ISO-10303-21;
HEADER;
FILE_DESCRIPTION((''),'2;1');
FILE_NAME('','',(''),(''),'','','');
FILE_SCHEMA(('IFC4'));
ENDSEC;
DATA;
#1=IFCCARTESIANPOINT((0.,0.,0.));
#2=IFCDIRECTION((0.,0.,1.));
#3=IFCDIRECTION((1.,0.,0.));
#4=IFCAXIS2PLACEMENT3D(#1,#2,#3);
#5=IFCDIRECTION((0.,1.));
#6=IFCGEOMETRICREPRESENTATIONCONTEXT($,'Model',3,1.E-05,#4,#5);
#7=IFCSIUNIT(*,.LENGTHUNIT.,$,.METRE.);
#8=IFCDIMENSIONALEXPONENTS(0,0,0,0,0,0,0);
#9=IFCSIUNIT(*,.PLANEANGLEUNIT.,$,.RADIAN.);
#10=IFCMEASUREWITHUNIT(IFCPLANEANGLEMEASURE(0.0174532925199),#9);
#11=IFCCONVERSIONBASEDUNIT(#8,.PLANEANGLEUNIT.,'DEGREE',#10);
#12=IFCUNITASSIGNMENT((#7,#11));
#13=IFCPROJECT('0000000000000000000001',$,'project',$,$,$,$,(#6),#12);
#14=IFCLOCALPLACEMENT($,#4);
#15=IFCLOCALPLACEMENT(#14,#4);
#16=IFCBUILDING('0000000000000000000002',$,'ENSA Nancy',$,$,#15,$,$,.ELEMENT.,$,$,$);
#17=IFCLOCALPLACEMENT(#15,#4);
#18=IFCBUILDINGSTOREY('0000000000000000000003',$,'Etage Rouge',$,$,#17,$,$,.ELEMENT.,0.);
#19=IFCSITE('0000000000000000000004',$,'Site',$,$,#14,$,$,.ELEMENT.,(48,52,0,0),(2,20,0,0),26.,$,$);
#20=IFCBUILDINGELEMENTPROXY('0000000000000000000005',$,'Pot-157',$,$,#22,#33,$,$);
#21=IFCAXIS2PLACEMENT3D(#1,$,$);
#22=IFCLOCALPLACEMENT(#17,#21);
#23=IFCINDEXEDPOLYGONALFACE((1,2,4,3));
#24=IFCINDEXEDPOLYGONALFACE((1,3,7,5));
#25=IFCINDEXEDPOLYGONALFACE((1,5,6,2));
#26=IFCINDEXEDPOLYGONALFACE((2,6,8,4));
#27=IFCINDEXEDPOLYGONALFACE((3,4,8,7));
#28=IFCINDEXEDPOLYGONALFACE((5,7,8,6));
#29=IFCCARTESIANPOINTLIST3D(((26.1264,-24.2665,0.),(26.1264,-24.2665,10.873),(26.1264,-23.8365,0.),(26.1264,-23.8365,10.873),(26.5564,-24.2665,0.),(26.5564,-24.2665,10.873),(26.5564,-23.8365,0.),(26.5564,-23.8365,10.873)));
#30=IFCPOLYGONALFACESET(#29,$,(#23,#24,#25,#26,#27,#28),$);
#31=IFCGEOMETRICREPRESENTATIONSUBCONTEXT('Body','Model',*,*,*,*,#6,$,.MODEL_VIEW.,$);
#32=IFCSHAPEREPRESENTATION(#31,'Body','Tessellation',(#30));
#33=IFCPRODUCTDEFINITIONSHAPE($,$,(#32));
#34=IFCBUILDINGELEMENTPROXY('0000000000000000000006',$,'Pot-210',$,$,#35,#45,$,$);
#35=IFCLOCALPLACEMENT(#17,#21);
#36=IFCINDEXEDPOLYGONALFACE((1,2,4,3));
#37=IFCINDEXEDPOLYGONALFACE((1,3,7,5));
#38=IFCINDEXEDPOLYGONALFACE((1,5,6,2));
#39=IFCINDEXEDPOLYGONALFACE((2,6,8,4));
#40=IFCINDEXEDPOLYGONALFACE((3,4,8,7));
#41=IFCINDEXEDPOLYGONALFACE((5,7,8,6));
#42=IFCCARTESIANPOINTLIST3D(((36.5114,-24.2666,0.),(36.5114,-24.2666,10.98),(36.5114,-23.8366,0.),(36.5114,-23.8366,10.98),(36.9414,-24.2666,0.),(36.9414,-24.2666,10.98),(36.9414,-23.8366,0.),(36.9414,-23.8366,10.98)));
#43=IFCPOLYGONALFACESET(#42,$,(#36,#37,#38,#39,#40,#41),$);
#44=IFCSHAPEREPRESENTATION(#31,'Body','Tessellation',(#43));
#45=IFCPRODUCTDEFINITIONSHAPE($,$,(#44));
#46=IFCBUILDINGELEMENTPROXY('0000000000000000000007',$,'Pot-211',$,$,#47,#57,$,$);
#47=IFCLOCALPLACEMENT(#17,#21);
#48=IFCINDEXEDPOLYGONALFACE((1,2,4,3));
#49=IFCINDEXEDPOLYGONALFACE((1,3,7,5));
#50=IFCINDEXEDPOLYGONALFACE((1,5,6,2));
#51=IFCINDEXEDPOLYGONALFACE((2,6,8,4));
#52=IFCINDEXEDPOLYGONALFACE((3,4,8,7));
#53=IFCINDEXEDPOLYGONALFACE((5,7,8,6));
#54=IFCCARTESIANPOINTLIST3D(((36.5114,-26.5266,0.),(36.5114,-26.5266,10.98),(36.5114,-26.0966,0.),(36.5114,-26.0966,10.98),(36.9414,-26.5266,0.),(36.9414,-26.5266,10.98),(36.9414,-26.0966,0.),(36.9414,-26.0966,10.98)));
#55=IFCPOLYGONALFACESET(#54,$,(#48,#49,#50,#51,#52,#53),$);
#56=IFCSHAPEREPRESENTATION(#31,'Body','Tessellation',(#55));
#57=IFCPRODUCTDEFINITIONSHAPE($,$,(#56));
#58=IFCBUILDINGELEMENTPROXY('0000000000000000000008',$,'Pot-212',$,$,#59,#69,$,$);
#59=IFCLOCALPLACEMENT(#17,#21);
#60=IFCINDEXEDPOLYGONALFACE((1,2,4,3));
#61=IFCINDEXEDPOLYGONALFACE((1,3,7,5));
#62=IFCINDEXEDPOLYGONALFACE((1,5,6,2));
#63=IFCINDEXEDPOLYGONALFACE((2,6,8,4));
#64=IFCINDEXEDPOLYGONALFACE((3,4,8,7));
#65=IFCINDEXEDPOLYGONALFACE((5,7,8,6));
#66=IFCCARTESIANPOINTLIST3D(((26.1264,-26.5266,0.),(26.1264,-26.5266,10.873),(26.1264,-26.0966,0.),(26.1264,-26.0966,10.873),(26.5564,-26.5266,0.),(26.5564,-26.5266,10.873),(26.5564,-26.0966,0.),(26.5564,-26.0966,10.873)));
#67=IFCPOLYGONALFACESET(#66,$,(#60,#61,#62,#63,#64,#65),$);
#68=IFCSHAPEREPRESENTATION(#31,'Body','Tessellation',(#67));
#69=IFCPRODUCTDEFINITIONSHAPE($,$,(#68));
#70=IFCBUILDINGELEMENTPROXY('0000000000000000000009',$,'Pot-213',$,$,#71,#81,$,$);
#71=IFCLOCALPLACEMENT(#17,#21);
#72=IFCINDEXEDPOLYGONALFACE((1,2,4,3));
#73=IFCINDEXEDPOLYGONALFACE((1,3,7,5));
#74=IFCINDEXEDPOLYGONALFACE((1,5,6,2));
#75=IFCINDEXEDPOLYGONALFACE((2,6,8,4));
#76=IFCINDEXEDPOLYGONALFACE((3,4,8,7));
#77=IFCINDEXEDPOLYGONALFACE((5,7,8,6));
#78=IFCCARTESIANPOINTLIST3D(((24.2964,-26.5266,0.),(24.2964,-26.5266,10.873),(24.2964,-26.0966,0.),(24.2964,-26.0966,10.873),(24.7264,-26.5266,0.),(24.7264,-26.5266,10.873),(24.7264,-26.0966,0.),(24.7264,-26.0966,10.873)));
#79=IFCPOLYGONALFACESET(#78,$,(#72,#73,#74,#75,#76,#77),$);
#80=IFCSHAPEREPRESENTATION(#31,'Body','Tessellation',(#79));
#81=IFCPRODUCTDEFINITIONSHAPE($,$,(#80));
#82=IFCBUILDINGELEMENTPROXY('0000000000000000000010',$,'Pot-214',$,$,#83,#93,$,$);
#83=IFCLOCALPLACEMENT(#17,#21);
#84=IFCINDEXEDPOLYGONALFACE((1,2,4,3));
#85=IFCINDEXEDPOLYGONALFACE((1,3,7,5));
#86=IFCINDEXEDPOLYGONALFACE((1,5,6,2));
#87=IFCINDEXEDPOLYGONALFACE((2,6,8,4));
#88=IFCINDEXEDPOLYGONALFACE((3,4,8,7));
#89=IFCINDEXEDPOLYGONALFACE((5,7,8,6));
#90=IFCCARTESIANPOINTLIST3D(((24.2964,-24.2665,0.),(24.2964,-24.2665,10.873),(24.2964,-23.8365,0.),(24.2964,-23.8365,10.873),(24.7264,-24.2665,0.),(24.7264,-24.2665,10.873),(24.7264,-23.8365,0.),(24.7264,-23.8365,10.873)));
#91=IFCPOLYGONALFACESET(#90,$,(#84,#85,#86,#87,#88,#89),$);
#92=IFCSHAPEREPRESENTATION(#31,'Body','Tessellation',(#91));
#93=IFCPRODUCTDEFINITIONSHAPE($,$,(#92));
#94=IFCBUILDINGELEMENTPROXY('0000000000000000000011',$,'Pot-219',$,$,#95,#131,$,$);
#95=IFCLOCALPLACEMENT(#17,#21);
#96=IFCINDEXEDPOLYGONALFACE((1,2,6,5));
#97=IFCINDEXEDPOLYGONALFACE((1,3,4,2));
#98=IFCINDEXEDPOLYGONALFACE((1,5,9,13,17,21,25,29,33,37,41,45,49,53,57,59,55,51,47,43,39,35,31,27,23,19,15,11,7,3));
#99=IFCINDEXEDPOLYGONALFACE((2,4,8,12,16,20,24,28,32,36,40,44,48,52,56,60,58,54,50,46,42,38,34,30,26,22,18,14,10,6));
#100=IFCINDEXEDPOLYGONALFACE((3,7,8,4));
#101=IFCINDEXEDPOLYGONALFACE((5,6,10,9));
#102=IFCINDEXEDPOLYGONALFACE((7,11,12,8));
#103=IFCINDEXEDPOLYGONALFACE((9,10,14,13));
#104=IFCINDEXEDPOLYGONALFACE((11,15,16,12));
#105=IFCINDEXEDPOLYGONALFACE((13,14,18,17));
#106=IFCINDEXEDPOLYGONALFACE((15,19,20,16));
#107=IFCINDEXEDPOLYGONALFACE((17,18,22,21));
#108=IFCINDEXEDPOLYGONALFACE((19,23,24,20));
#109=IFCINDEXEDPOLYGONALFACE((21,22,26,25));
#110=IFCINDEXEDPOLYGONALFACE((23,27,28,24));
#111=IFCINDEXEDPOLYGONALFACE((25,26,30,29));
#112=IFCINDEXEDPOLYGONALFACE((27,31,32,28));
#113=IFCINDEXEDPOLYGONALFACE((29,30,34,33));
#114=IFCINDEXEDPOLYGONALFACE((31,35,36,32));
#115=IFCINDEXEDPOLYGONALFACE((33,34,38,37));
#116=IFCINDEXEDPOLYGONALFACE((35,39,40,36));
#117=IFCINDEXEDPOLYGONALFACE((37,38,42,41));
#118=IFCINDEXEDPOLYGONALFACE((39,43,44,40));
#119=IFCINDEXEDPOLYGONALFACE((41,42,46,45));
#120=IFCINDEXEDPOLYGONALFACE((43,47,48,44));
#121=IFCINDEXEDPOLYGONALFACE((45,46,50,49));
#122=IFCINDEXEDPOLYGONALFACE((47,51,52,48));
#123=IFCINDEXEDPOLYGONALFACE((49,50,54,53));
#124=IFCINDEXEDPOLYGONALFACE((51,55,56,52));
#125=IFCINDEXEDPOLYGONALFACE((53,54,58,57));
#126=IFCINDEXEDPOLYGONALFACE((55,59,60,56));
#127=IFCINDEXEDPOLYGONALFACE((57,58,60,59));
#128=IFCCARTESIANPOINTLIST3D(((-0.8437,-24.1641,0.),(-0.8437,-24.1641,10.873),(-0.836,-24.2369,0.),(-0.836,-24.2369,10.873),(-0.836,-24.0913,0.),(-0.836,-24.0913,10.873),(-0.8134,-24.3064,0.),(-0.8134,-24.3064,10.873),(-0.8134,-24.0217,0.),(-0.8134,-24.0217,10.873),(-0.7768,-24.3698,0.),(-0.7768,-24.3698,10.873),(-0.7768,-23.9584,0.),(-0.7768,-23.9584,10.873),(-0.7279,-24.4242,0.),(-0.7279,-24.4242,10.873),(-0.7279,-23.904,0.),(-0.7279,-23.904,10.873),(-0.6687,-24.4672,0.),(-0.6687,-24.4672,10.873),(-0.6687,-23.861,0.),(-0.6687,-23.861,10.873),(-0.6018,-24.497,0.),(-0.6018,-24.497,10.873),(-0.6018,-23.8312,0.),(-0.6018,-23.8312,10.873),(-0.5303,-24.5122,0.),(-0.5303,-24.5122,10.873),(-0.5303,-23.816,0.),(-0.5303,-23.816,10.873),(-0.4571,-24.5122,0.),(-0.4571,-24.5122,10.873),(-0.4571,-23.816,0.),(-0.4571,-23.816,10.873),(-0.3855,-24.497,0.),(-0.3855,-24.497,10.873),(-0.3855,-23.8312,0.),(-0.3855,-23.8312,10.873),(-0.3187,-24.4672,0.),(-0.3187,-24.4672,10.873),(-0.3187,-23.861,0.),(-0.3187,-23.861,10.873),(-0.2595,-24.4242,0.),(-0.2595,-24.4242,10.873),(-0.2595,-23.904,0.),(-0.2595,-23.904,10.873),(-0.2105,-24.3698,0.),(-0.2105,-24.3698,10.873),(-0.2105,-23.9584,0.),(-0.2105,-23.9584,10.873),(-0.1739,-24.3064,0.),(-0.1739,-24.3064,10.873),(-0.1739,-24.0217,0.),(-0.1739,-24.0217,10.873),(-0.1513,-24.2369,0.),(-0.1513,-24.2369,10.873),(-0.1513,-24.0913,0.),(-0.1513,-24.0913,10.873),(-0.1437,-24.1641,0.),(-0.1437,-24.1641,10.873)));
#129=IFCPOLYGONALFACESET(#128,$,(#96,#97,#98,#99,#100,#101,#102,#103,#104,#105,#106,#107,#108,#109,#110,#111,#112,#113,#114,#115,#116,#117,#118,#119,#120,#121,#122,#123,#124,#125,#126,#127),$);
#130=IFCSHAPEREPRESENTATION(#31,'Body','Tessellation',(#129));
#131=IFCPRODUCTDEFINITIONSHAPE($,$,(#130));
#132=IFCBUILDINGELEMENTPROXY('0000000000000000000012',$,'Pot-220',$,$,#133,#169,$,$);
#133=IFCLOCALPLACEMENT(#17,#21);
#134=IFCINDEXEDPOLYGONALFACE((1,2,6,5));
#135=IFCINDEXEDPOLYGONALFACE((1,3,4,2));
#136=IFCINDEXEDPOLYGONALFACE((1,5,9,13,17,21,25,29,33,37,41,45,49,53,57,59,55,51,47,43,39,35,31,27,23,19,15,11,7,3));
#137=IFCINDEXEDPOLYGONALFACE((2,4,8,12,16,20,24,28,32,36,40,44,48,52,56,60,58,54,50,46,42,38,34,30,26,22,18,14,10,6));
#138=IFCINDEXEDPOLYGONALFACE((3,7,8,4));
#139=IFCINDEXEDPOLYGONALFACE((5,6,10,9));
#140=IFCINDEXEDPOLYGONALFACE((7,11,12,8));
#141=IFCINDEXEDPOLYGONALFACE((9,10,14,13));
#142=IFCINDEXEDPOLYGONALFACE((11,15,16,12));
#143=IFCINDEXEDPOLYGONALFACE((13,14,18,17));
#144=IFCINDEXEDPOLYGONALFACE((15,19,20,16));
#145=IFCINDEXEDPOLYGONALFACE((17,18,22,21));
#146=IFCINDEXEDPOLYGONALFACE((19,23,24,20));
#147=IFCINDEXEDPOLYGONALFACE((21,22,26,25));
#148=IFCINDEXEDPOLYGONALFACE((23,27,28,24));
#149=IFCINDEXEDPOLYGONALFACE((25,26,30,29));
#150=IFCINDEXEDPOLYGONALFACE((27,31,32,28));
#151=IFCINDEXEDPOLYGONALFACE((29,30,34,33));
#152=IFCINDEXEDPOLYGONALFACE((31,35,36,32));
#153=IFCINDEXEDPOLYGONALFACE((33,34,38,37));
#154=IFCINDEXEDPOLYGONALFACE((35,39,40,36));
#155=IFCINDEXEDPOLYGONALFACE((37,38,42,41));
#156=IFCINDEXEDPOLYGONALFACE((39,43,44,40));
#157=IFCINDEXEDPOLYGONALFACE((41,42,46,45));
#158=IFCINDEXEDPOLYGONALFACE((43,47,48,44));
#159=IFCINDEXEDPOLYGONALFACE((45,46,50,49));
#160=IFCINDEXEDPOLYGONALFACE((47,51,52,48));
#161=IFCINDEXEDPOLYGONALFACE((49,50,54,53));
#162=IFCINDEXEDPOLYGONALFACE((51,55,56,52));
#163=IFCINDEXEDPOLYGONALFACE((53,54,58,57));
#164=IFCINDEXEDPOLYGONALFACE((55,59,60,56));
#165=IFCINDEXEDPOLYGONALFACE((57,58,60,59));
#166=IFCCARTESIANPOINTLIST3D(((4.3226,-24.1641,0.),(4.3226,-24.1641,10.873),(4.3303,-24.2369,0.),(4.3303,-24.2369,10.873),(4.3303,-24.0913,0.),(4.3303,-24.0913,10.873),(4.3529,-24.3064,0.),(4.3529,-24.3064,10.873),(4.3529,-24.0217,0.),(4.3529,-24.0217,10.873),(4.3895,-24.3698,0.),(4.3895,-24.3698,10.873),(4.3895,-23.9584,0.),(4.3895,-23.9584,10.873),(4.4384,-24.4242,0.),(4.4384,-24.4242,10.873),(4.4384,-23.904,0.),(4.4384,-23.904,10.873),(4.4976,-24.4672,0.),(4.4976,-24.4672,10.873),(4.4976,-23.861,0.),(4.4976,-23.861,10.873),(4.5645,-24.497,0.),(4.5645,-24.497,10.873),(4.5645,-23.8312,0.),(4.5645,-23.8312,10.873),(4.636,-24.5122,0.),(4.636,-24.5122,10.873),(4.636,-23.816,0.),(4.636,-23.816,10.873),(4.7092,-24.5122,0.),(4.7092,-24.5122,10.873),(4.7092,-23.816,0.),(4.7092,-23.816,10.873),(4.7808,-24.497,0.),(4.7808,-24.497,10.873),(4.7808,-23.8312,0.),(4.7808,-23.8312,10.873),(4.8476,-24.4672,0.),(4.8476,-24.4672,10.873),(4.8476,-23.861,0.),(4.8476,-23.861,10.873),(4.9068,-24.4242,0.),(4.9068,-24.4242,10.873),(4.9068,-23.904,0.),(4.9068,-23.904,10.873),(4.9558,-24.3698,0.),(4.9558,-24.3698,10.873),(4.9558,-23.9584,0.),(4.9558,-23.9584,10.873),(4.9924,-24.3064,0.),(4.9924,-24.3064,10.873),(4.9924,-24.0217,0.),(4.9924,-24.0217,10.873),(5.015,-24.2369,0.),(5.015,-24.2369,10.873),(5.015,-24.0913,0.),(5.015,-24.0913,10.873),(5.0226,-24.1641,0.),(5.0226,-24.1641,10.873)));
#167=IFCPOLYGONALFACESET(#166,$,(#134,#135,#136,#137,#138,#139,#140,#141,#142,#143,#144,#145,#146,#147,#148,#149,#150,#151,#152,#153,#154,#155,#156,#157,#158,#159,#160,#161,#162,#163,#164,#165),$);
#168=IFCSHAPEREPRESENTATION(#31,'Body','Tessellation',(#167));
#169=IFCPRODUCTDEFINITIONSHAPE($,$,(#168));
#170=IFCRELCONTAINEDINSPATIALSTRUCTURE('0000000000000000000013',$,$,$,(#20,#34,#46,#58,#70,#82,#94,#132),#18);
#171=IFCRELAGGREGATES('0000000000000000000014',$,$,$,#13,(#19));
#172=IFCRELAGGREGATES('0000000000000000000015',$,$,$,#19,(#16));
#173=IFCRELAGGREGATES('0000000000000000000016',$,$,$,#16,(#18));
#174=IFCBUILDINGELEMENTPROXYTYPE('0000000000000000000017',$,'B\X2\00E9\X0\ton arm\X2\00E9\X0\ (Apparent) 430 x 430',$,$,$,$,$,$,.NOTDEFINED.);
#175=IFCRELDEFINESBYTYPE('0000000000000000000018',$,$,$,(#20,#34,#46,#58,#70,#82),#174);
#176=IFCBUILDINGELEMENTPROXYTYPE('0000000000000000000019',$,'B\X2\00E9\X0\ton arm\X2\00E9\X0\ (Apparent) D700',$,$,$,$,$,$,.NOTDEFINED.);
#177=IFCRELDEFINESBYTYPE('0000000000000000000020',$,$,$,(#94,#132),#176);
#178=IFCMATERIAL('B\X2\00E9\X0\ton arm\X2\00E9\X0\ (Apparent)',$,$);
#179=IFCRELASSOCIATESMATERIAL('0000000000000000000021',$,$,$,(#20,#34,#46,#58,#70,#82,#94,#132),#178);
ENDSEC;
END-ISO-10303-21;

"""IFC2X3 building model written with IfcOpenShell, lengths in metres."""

from ifc_helpers import new_model, entity, si_unit, converted_unit, direction, frame, origin_with_axes, origin_2d_with_axis, place, context, subcontext, project, spatial, rectangle, circle, extrude, material, type_object, element, save


model = new_model("IFC2X3")

# Units and contexts
model_context = context("Model", 3, precision=1e-05, world=origin_with_axes(), true_north=direction((0.0, 1.0)))
body_context = subcontext(model_context, "Body", "Model", "MODEL_VIEW")
ifc_project = project(units=[si_unit("LENGTHUNIT", "METRE"), converted_unit("PLANEANGLEUNIT", "DEGREE", entity("IfcPlaneAngleMeasure", 0.0174532925199), si_unit("PLANEANGLEUNIT", "RADIAN"), dimensions=[0, 0, 0, 0, 0, 0, 0])], contexts=[model_context])

# Site, building, storey
site_placement = place(None, origin_with_axes())
site = spatial("IfcSite", under=ifc_project, at=site_placement, Name="Site", CompositionType="ELEMENT", RefLatitude=(48, 52, 0, 0), RefLongitude=(2, 20, 0, 0), RefElevation=26.0)
building_placement = place(site_placement, origin_with_axes())
building = spatial("IfcBuilding", under=site, at=building_placement, Name="ENSA Nancy", CompositionType="ELEMENT")
storey_placement = place(building_placement, origin_with_axes())
storey = spatial("IfcBuildingStorey", under=building, at=storey_placement, Name="Etage Rouge", CompositionType="ELEMENT", Elevation=0.0)

# Building element proxies
ifc_material_1 = material(Name="Béton armé (Apparent)")
building_element_proxy_type_1 = type_object("IfcBuildingElementProxyType", Name="Béton armé (Apparent) 430 x 430", PredefinedType="NOTDEFINED")
for number, where, z_axis, x_axis, name in (
    (1, (26.3414, -24.0515, 0.0), (0.0, 0.0, 1.0), (1.0, 0.0, 0.0), "Pot-157"),
):
    element("IfcBuildingElementProxy", number, at=place(storey_placement, frame(where, z_axis=z_axis, x_axis=x_axis)), inside=storey, type_object=building_element_proxy_type_1, material=ifc_material_1, Name=name, context=body_context, shape_type="SweptSolid", body=[
        extrude(rectangle(XDim=0.43, YDim=0.43, at=origin_2d_with_axis()), origin_with_axes(), (0.0, 0.0, 1.0), 10.873),
    ])
for number, where, z_axis, x_axis, name in (
    (2, (36.7264, -24.0516, 0.0), (0.0, 0.0, 1.0), (1.0, 0.0, 0.0), "Pot-210"),
    (3, (36.7264, -26.3116, 0.0), (0.0, 0.0, 1.0), (1.0, 0.0, 0.0), "Pot-211"),
):
    element("IfcBuildingElementProxy", number, at=place(storey_placement, frame(where, z_axis=z_axis, x_axis=x_axis)), inside=storey, type_object=building_element_proxy_type_1, material=ifc_material_1, Name=name, context=body_context, shape_type="SweptSolid", body=[
        extrude(rectangle(XDim=0.43, YDim=0.43, at=origin_2d_with_axis()), origin_with_axes(), (0.0, 0.0, 1.0), 10.98),
    ])
for number, where, z_axis, x_axis, name in (
    (4, (26.3414, -26.3116, 0.0), (0.0, 0.0, 1.0), (1.0, 0.0, 0.0), "Pot-212"),
    (5, (24.5114, -26.3116, 0.0), (0.0, 0.0, 1.0), (1.0, 0.0, 0.0), "Pot-213"),
    (6, (24.5114, -24.0515, 0.0), (0.0, 0.0, 1.0), (1.0, 0.0, 0.0), "Pot-214"),
):
    element("IfcBuildingElementProxy", number, at=place(storey_placement, frame(where, z_axis=z_axis, x_axis=x_axis)), inside=storey, type_object=building_element_proxy_type_1, material=ifc_material_1, Name=name, context=body_context, shape_type="SweptSolid", body=[
        extrude(rectangle(XDim=0.43, YDim=0.43, at=origin_2d_with_axis()), origin_with_axes(), (0.0, 0.0, 1.0), 10.873),
    ])
building_element_proxy_type_2 = type_object("IfcBuildingElementProxyType", Name="Béton armé (Apparent) D700", PredefinedType="NOTDEFINED")
for number, where, z_axis, x_axis, name in (
    (7, (-0.4937, -24.1641, 0.0), (0.0, 0.0, 1.0), (1.0, 0.0, 0.0), "Pot-219"),
    (8, (4.6726, -24.1641, 0.0), (0.0, 0.0, 1.0), (1.0, 0.0, 0.0), "Pot-220"),
):
    element("IfcBuildingElementProxy", number, at=place(storey_placement, frame(where, z_axis=z_axis, x_axis=x_axis)), inside=storey, type_object=building_element_proxy_type_2, material=ifc_material_1, Name=name, context=body_context, shape_type="SweptSolid", body=[
        extrude(circle(Radius=0.35, at=origin_2d_with_axis()), origin_with_axes(), (0.0, 0.0, 1.0), 10.873),
    ])

save(model, "model.ifc")
